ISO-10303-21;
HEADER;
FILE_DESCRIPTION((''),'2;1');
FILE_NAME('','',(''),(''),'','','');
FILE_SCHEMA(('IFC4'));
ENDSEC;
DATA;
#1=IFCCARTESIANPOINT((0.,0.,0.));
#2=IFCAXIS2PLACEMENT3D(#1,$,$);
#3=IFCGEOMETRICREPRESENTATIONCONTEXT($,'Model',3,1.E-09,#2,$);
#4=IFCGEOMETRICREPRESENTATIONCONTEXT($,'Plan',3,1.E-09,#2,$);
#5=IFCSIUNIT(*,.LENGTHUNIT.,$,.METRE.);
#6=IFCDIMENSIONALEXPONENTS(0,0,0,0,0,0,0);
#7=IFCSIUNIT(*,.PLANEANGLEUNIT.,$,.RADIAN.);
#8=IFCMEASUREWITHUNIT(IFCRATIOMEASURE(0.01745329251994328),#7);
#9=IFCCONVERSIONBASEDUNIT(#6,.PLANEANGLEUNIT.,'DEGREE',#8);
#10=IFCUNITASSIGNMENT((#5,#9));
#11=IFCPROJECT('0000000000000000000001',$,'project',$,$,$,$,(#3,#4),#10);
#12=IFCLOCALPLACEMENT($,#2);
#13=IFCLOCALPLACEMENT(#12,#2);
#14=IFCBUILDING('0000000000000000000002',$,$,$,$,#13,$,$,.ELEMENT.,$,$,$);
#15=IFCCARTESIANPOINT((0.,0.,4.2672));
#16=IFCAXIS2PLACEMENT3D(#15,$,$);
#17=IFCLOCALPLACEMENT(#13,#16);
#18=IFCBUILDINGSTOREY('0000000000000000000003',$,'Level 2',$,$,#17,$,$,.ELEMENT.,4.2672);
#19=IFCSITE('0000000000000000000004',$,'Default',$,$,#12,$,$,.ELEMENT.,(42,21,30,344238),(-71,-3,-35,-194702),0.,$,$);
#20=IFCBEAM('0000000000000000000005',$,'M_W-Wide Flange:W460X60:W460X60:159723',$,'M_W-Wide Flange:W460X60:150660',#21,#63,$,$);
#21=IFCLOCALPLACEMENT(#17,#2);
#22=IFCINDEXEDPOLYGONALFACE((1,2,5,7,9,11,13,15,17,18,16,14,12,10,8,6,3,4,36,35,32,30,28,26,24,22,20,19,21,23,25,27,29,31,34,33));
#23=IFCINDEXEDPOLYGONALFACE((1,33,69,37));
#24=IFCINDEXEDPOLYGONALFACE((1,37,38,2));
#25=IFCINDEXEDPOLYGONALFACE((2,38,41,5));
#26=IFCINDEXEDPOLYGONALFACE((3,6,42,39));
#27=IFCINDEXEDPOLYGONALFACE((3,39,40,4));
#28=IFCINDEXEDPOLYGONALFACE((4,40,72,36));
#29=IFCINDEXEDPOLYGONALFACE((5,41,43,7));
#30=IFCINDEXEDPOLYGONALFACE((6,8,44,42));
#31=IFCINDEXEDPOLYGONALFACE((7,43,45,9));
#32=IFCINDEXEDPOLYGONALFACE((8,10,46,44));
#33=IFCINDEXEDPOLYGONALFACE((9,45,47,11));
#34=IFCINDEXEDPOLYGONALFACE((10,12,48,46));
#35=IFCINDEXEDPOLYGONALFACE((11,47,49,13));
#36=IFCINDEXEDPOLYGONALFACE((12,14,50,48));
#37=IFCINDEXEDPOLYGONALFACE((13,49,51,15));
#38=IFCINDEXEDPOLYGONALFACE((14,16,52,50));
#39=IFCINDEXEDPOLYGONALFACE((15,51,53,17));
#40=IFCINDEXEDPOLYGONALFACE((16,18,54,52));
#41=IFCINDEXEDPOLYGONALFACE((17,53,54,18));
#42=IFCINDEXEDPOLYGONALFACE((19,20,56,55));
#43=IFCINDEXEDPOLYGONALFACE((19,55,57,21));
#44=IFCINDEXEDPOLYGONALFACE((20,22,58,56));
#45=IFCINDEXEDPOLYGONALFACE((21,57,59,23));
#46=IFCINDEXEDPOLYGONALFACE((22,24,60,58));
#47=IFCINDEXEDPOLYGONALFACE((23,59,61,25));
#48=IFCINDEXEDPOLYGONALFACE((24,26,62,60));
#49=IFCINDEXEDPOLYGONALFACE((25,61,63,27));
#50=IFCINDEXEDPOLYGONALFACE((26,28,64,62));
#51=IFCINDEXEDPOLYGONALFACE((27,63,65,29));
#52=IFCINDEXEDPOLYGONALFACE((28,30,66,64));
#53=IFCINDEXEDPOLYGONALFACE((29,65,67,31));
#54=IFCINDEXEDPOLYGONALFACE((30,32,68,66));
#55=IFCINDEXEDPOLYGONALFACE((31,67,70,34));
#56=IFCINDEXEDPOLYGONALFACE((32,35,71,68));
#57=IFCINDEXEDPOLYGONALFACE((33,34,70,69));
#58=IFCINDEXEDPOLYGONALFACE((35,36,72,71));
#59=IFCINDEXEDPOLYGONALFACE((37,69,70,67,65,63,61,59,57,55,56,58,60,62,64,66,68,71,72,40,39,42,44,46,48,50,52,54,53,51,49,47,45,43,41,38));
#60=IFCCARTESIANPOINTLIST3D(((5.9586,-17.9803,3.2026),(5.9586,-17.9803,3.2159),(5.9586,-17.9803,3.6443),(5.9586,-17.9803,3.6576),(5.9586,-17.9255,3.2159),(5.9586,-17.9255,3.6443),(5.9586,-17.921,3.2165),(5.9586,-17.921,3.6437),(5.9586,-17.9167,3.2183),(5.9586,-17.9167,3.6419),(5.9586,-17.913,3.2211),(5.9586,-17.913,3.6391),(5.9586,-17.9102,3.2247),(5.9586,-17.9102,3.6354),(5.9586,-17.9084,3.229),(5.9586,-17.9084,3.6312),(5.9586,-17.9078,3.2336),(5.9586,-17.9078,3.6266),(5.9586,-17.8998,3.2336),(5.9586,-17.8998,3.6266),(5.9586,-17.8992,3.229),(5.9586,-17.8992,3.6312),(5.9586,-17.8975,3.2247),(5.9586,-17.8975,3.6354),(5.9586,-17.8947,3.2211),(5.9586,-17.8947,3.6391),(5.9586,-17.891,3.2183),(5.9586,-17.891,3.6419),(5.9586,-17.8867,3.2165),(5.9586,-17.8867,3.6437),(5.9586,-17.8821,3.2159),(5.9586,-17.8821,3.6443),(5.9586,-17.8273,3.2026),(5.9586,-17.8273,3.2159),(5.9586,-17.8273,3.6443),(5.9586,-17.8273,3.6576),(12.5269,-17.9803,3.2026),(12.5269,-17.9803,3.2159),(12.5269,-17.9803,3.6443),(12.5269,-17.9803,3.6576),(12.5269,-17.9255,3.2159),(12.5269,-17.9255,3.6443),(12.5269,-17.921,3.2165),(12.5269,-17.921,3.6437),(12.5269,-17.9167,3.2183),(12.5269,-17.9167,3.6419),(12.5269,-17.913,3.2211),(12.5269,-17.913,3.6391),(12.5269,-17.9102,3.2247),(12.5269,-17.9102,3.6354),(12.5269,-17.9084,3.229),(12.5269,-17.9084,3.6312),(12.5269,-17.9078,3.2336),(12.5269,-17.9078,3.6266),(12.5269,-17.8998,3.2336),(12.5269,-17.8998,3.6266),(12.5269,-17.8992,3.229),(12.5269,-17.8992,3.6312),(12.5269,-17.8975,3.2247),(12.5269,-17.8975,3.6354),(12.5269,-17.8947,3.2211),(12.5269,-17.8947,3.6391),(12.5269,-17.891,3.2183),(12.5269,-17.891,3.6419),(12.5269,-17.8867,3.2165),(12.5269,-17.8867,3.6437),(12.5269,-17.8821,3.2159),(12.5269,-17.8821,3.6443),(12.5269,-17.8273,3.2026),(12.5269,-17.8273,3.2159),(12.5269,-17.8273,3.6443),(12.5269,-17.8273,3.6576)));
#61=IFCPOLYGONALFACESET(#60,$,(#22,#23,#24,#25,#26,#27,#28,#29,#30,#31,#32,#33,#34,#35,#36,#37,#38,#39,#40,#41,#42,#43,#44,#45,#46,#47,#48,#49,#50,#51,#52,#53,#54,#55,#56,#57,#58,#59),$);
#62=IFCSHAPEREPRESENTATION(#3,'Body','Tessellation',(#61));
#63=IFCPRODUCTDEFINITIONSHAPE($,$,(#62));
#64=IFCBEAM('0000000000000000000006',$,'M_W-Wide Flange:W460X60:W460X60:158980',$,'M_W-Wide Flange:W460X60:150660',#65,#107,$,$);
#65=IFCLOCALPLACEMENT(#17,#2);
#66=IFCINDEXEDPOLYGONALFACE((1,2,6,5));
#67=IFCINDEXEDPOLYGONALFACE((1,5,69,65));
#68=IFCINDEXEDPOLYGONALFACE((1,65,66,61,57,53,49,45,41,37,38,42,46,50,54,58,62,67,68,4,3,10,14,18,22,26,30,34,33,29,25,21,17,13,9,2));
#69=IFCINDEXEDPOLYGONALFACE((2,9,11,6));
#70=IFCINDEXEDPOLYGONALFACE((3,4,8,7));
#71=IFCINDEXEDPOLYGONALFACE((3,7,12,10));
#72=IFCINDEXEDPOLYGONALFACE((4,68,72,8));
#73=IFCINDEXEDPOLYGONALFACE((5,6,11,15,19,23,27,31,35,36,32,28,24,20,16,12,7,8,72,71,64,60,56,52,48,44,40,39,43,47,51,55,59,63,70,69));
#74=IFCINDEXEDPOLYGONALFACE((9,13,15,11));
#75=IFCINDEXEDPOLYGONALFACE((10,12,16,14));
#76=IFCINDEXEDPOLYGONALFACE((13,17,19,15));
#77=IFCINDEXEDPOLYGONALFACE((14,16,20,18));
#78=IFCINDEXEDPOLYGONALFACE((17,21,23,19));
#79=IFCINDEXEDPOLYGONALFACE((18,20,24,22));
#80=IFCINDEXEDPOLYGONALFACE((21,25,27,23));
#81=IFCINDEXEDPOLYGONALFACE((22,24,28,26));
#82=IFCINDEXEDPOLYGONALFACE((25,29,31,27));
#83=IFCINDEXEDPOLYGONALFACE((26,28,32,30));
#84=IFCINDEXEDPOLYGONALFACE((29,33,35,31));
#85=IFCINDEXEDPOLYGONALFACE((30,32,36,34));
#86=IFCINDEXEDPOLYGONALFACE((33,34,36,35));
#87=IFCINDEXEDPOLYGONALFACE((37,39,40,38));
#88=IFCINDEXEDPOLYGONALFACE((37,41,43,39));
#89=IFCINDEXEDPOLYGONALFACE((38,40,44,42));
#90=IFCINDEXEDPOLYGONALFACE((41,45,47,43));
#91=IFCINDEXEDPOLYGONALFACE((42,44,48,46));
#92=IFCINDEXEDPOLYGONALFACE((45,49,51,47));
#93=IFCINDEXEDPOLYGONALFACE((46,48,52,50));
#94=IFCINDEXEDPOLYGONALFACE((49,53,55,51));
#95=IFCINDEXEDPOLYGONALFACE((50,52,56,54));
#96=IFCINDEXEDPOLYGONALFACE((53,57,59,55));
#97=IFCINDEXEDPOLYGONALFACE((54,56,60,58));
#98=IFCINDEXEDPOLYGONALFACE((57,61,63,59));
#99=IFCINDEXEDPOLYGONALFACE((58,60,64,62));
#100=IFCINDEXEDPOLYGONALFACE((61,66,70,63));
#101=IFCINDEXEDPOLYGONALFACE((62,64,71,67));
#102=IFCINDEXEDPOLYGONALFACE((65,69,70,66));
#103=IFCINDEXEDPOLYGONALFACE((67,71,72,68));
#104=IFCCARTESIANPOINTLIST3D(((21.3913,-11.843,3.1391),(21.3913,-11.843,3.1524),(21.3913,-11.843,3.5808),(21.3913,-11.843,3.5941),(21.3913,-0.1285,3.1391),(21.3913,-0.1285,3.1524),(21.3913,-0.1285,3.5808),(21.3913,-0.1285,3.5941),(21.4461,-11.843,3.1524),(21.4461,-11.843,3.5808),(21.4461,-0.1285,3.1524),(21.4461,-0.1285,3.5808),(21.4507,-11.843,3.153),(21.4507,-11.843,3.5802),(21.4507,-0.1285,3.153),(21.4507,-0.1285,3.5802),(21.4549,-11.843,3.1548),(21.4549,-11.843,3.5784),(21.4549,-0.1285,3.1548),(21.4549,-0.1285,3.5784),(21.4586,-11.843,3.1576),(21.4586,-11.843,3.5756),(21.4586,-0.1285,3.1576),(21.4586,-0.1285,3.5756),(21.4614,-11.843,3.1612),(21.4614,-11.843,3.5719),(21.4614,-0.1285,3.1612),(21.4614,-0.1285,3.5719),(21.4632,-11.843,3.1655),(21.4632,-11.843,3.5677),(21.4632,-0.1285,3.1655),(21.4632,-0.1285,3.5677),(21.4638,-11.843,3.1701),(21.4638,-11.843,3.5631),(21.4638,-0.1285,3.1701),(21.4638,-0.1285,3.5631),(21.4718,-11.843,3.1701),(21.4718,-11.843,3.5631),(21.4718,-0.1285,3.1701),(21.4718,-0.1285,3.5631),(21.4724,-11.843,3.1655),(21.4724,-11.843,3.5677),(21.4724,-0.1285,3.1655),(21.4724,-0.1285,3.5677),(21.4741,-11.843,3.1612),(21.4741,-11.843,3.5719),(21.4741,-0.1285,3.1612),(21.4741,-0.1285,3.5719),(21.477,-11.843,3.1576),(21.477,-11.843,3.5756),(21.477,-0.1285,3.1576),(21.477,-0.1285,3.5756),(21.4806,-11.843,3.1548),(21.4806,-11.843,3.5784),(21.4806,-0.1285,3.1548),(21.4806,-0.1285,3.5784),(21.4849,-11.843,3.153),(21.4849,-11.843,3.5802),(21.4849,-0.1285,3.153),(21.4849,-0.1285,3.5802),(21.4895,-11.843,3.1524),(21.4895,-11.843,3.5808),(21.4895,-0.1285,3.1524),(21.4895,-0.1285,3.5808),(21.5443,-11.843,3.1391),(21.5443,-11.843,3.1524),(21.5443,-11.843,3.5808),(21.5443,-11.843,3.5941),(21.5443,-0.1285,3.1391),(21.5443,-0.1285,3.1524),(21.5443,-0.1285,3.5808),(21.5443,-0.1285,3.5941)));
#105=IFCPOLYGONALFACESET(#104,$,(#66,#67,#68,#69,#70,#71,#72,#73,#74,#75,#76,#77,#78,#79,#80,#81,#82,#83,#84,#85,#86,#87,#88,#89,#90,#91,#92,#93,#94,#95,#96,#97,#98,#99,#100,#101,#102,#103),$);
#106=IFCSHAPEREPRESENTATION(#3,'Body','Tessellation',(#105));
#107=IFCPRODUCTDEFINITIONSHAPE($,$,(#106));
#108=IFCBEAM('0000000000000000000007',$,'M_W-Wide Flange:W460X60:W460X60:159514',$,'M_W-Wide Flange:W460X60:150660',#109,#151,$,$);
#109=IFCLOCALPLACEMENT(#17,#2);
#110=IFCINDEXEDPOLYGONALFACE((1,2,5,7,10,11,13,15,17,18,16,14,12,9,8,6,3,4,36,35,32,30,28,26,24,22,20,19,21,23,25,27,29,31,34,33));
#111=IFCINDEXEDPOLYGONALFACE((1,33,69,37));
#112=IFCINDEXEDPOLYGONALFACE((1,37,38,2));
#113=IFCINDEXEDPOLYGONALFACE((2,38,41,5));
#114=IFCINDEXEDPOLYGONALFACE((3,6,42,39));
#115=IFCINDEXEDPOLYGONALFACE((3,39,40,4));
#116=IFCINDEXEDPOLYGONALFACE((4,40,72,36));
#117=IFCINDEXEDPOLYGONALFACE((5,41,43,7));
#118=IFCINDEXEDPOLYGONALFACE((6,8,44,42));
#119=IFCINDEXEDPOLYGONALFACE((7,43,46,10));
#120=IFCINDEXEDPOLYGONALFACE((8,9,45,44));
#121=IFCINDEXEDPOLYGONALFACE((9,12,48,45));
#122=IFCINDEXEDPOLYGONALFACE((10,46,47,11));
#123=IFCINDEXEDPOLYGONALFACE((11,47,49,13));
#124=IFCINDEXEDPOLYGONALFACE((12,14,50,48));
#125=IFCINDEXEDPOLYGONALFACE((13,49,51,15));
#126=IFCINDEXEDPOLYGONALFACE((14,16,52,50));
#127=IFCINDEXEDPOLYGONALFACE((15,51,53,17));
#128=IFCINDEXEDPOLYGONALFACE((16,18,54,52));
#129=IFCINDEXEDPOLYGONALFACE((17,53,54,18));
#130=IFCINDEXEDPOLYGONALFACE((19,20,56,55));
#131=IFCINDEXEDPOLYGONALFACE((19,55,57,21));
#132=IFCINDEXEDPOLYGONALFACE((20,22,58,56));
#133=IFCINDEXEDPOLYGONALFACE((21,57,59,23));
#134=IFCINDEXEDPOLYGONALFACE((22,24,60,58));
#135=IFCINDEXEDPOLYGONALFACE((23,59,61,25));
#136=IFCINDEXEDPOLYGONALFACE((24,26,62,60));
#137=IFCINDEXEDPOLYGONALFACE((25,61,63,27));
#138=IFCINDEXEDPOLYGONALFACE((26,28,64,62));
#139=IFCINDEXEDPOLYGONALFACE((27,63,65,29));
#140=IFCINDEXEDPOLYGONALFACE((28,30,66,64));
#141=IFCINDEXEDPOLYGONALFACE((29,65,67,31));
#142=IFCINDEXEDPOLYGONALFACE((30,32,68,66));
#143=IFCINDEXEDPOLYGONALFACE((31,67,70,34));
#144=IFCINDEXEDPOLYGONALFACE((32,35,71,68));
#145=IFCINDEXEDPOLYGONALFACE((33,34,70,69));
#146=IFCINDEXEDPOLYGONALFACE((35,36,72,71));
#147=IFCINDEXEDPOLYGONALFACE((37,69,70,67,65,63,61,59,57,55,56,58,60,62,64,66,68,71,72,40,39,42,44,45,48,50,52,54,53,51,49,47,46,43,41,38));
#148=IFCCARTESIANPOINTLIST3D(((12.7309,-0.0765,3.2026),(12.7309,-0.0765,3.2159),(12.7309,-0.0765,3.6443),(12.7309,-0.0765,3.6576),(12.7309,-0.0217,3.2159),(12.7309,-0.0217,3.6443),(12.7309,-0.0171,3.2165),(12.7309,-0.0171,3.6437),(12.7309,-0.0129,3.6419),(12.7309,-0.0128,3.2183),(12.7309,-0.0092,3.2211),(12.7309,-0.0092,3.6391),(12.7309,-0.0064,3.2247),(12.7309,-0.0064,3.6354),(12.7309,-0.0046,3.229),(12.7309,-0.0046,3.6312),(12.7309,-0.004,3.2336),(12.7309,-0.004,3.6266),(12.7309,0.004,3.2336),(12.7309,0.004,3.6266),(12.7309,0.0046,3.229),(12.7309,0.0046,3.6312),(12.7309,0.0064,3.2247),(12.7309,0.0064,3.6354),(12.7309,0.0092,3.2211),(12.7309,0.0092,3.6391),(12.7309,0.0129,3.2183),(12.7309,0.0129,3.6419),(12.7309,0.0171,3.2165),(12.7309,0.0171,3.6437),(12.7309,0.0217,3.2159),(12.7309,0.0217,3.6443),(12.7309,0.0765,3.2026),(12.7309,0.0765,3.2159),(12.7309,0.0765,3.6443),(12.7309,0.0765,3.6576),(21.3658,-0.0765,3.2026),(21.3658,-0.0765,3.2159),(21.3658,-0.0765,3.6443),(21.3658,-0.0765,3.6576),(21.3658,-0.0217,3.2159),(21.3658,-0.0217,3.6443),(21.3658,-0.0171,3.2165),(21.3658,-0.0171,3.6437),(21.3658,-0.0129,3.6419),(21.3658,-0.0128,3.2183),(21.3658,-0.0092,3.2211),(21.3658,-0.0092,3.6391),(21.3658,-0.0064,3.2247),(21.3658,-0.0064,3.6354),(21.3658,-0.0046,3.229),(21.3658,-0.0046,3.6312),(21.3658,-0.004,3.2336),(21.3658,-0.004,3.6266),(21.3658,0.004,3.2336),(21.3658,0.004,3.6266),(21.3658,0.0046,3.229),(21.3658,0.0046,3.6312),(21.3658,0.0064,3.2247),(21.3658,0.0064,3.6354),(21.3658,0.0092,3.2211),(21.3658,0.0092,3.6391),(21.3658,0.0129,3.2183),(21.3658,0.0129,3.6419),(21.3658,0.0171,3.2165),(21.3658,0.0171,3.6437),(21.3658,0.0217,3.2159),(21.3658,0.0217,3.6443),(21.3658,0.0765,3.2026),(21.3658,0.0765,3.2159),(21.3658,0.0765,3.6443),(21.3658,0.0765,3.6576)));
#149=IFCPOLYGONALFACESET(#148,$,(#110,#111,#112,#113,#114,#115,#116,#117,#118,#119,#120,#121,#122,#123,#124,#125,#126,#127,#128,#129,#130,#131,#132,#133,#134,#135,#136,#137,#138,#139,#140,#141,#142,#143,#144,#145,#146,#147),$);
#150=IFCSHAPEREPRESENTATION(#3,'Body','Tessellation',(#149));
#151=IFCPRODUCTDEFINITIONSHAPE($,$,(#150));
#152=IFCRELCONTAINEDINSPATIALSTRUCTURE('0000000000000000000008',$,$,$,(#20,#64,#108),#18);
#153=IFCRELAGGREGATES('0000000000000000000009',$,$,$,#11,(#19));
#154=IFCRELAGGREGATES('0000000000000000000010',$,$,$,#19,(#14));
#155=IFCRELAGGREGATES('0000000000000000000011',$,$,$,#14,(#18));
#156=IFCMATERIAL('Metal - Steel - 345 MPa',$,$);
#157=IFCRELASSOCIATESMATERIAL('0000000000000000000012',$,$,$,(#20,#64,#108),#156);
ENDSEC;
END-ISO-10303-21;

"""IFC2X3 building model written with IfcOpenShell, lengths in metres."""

from ifc_helpers import new_model, entity, si_unit, converted_unit, frame, frame_2d, origin, place, context, project, spatial, polyline, circle_curve, parameter, trimmed, segment, composite_curve, outline, extrude, material, element, save


model = new_model("IFC2X3")

# Units and contexts
model_context = context("Model", 3, precision=1e-09, world=origin())
plan_context = context("Plan", 3, precision=1e-09, world=origin())
ifc_project = project(units=[si_unit("LENGTHUNIT", "METRE"), converted_unit("PLANEANGLEUNIT", "DEGREE", entity("IfcRatioMeasure", 0.01745329251994328), si_unit("PLANEANGLEUNIT", "RADIAN"), dimensions=[0, 0, 0, 0, 0, 0, 0])], contexts=[model_context, plan_context])

# Site, building, storey
site_placement = place(None, origin())
site = spatial("IfcSite", under=ifc_project, at=site_placement, Name="Default", CompositionType="ELEMENT", RefLatitude=(42, 21, 30, 344238), RefLongitude=(-71, -3, -35, -194702), RefElevation=0.0)
building_placement = place(site_placement, origin())
building = spatial("IfcBuilding", under=site, at=building_placement, CompositionType="ELEMENT")
storey_placement = place(building_placement, frame((0.0, 0.0, 4.2672)))
storey = spatial("IfcBuildingStorey", under=building, at=storey_placement, Name="Level 2", CompositionType="ELEMENT", Elevation=4.2672)

# Shared definitions
ifc_material = material(Name="Metal - Steel - 345 MPa")

# Beams
beam_1_placement = place(storey_placement, frame((5.8566, -17.9038, 3.6576), z_axis=(0.0, 0.0, 1.0), x_axis=(0.0, -1.0, 0.0)))
element("IfcBeam", 1, at=beam_1_placement, inside=storey, material=ifc_material, Name="M_W-Wide Flange:W460X60:W460X60:159723", ObjectType="M_W-Wide Flange:W460X60:150660", context=model_context, shape_type="SweptSolid", body=[
    extrude(outline(composite_curve([segment(polyline([(-0.0765, -0.2142), (-0.0765, -0.2275)]), True, "CONTINUOUS"), segment(polyline([(-0.0765, -0.2275), (0.0765, -0.2275)]), True, "CONTINUOUS"), segment(polyline([(0.0765, -0.2275), (0.0765, -0.2142)]), True, "CONTINUOUS"), segment(polyline([(0.0765, -0.2142), (0.0217, -0.2142)]), True, "CONTINUOUS"), segment(trimmed(circle_curve(frame_2d((0.0217, -0.1965), x_axis=(0.0, -1.0)), 0.0177), [parameter(270.0)], [parameter(360.0)], True, "PARAMETER"), False, "CONTINUOUS"), segment(polyline([(0.004, -0.1965), (0.004, 0.1965)]), True, "CONTINUOUS"), segment(trimmed(circle_curve(frame_2d((0.0217, 0.1965), x_axis=(-1.0, 0.0)), 0.0177), [parameter(270.0)], [parameter(360.0)], True, "PARAMETER"), False, "CONTINUOUS"), segment(polyline([(0.0217, 0.2142), (0.0765, 0.2142)]), True, "CONTINUOUS"), segment(polyline([(0.0765, 0.2142), (0.0765, 0.2275)]), True, "CONTINUOUS"), segment(polyline([(0.0765, 0.2275), (-0.0765, 0.2275)]), True, "CONTINUOUS"), segment(polyline([(-0.0765, 0.2275), (-0.0765, 0.2142)]), True, "CONTINUOUS"), segment(polyline([(-0.0765, 0.2142), (-0.0217, 0.2142)]), True, "CONTINUOUS"), segment(trimmed(circle_curve(frame_2d((-0.0217, 0.1965), x_axis=(0.0, 1.0)), 0.0177), [parameter(270.0)], [parameter(360.0)], True, "PARAMETER"), False, "CONTINUOUS"), segment(polyline([(-0.004, 0.1965), (-0.004, -0.1965)]), True, "CONTINUOUS"), segment(trimmed(circle_curve(frame_2d((-0.0217, -0.1965), x_axis=(1.0, 0.0)), 0.0177), [parameter(270.0)], [parameter(0.0)], True, "PARAMETER"), False, "CONTINUOUS"), segment(polyline([(-0.0217, -0.2142), (-0.0765, -0.2142)]), True, "CONTINUOUS")], self_intersect=False)), frame((0.0, 0.102, -0.2275), z_axis=(0.0, -1.0, 0.0), x_axis=(1.0, 0.0, 0.0)), (0.0, 0.0, -1.0), 6.5683),
])
beam_2_placement = place(storey_placement, frame((21.4678, 0.0, 3.6576), z_axis=(0.0, 0.0, 1.0), x_axis=(-1.0, 0.0, 0.0)))
element("IfcBeam", 2, at=beam_2_placement, inside=storey, material=ifc_material, Name="M_W-Wide Flange:W460X60:W460X60:158980", ObjectType="M_W-Wide Flange:W460X60:150660", context=model_context, shape_type="SweptSolid", body=[
    extrude(outline(composite_curve([segment(polyline([(0.2142, -0.0765), (0.2275, -0.0765)]), True, "CONTINUOUS"), segment(polyline([(0.2275, -0.0765), (0.2275, 0.0765)]), True, "CONTINUOUS"), segment(polyline([(0.2275, 0.0765), (0.2142, 0.0765)]), True, "CONTINUOUS"), segment(polyline([(0.2142, 0.0765), (0.2142, 0.0217)]), True, "CONTINUOUS"), segment(trimmed(circle_curve(frame_2d((0.1965, 0.0217), x_axis=(0.0, 1.0)), 0.0177), [parameter(180.0)], [parameter(270.0)], True, "PARAMETER"), False, "CONTINUOUS"), segment(polyline([(0.1965, 0.004), (-0.1965, 0.004)]), True, "CONTINUOUS"), segment(trimmed(circle_curve(frame_2d((-0.1965, 0.0217), x_axis=(0.0, 1.0)), 0.0177), [parameter(90.0)], [parameter(180.0)], True, "PARAMETER"), False, "CONTINUOUS"), segment(polyline([(-0.2142, 0.0217), (-0.2142, 0.0765)]), True, "CONTINUOUS"), segment(polyline([(-0.2142, 0.0765), (-0.2275, 0.0765)]), True, "CONTINUOUS"), segment(polyline([(-0.2275, 0.0765), (-0.2275, -0.0765)]), True, "CONTINUOUS"), segment(polyline([(-0.2275, -0.0765), (-0.2142, -0.0765)]), True, "CONTINUOUS"), segment(polyline([(-0.2142, -0.0765), (-0.2142, -0.0217)]), True, "CONTINUOUS"), segment(trimmed(circle_curve(frame_2d((-0.1965, -0.0217), x_axis=(0.0, 1.0)), 0.0177), [parameter(360.0)], [parameter(90.0)], True, "PARAMETER"), False, "CONTINUOUS"), segment(polyline([(-0.1965, -0.004), (0.1965, -0.004)]), True, "CONTINUOUS"), segment(trimmed(circle_curve(frame_2d((0.1965, -0.0217), x_axis=(0.0, 1.0)), 0.0177), [parameter(270.0)], [parameter(0.0)], True, "PARAMETER"), False, "CONTINUOUS"), segment(polyline([(0.2142, -0.0217), (0.2142, -0.0765)]), True, "CONTINUOUS")], self_intersect=False)), frame((0.0, 11.843, -0.291), z_axis=(0.0, -1.0, 0.0), x_axis=(0.0, 0.0, -1.0)), (0.0, 0.0, 1.0), 11.7145),
])
beam_3_placement = place(storey_placement, frame((12.6289, 0.0, 3.6576), z_axis=(0.0, 0.0, 1.0), x_axis=(0.0, -1.0, 0.0)))
element("IfcBeam", 3, at=beam_3_placement, inside=storey, material=ifc_material, Name="M_W-Wide Flange:W460X60:W460X60:159514", ObjectType="M_W-Wide Flange:W460X60:150660", context=model_context, shape_type="SweptSolid", body=[
    extrude(outline(composite_curve([segment(polyline([(-0.0765, -0.2142), (-0.0765, -0.2275)]), True, "CONTINUOUS"), segment(polyline([(-0.0765, -0.2275), (0.0765, -0.2275)]), True, "CONTINUOUS"), segment(polyline([(0.0765, -0.2275), (0.0765, -0.2142)]), True, "CONTINUOUS"), segment(polyline([(0.0765, -0.2142), (0.0217, -0.2142)]), True, "CONTINUOUS"), segment(trimmed(circle_curve(frame_2d((0.0217, -0.1965), x_axis=(0.0, -1.0)), 0.0177), [parameter(270.0)], [parameter(360.0)], True, "PARAMETER"), False, "CONTINUOUS"), segment(polyline([(0.004, -0.1965), (0.004, 0.1965)]), True, "CONTINUOUS"), segment(trimmed(circle_curve(frame_2d((0.0217, 0.1965), x_axis=(-1.0, 0.0)), 0.0177), [parameter(270.0)], [parameter(360.0)], True, "PARAMETER"), False, "CONTINUOUS"), segment(polyline([(0.0217, 0.2142), (0.0765, 0.2142)]), True, "CONTINUOUS"), segment(polyline([(0.0765, 0.2142), (0.0765, 0.2275)]), True, "CONTINUOUS"), segment(polyline([(0.0765, 0.2275), (-0.0765, 0.2275)]), True, "CONTINUOUS"), segment(polyline([(-0.0765, 0.2275), (-0.0765, 0.2142)]), True, "CONTINUOUS"), segment(polyline([(-0.0765, 0.2142), (-0.0217, 0.2142)]), True, "CONTINUOUS"), segment(trimmed(circle_curve(frame_2d((-0.0217, 0.1965), x_axis=(0.0, 1.0)), 0.0177), [parameter(270.0)], [parameter(360.0)], True, "PARAMETER"), False, "CONTINUOUS"), segment(polyline([(-0.004, 0.1965), (-0.004, -0.1965)]), True, "CONTINUOUS"), segment(trimmed(circle_curve(frame_2d((-0.0217, -0.1965), x_axis=(1.0, 0.0)), 0.0177), [parameter(270.0)], [parameter(0.0)], True, "PARAMETER"), False, "CONTINUOUS"), segment(polyline([(-0.0217, -0.2142), (-0.0765, -0.2142)]), True, "CONTINUOUS")], self_intersect=False)), frame((0.0, 0.102, -0.2275), z_axis=(0.0, -1.0, 0.0), x_axis=(1.0, 0.0, 0.0)), (0.0, 0.0, -1.0), 8.6349),
])

save(model, "model.ifc")
